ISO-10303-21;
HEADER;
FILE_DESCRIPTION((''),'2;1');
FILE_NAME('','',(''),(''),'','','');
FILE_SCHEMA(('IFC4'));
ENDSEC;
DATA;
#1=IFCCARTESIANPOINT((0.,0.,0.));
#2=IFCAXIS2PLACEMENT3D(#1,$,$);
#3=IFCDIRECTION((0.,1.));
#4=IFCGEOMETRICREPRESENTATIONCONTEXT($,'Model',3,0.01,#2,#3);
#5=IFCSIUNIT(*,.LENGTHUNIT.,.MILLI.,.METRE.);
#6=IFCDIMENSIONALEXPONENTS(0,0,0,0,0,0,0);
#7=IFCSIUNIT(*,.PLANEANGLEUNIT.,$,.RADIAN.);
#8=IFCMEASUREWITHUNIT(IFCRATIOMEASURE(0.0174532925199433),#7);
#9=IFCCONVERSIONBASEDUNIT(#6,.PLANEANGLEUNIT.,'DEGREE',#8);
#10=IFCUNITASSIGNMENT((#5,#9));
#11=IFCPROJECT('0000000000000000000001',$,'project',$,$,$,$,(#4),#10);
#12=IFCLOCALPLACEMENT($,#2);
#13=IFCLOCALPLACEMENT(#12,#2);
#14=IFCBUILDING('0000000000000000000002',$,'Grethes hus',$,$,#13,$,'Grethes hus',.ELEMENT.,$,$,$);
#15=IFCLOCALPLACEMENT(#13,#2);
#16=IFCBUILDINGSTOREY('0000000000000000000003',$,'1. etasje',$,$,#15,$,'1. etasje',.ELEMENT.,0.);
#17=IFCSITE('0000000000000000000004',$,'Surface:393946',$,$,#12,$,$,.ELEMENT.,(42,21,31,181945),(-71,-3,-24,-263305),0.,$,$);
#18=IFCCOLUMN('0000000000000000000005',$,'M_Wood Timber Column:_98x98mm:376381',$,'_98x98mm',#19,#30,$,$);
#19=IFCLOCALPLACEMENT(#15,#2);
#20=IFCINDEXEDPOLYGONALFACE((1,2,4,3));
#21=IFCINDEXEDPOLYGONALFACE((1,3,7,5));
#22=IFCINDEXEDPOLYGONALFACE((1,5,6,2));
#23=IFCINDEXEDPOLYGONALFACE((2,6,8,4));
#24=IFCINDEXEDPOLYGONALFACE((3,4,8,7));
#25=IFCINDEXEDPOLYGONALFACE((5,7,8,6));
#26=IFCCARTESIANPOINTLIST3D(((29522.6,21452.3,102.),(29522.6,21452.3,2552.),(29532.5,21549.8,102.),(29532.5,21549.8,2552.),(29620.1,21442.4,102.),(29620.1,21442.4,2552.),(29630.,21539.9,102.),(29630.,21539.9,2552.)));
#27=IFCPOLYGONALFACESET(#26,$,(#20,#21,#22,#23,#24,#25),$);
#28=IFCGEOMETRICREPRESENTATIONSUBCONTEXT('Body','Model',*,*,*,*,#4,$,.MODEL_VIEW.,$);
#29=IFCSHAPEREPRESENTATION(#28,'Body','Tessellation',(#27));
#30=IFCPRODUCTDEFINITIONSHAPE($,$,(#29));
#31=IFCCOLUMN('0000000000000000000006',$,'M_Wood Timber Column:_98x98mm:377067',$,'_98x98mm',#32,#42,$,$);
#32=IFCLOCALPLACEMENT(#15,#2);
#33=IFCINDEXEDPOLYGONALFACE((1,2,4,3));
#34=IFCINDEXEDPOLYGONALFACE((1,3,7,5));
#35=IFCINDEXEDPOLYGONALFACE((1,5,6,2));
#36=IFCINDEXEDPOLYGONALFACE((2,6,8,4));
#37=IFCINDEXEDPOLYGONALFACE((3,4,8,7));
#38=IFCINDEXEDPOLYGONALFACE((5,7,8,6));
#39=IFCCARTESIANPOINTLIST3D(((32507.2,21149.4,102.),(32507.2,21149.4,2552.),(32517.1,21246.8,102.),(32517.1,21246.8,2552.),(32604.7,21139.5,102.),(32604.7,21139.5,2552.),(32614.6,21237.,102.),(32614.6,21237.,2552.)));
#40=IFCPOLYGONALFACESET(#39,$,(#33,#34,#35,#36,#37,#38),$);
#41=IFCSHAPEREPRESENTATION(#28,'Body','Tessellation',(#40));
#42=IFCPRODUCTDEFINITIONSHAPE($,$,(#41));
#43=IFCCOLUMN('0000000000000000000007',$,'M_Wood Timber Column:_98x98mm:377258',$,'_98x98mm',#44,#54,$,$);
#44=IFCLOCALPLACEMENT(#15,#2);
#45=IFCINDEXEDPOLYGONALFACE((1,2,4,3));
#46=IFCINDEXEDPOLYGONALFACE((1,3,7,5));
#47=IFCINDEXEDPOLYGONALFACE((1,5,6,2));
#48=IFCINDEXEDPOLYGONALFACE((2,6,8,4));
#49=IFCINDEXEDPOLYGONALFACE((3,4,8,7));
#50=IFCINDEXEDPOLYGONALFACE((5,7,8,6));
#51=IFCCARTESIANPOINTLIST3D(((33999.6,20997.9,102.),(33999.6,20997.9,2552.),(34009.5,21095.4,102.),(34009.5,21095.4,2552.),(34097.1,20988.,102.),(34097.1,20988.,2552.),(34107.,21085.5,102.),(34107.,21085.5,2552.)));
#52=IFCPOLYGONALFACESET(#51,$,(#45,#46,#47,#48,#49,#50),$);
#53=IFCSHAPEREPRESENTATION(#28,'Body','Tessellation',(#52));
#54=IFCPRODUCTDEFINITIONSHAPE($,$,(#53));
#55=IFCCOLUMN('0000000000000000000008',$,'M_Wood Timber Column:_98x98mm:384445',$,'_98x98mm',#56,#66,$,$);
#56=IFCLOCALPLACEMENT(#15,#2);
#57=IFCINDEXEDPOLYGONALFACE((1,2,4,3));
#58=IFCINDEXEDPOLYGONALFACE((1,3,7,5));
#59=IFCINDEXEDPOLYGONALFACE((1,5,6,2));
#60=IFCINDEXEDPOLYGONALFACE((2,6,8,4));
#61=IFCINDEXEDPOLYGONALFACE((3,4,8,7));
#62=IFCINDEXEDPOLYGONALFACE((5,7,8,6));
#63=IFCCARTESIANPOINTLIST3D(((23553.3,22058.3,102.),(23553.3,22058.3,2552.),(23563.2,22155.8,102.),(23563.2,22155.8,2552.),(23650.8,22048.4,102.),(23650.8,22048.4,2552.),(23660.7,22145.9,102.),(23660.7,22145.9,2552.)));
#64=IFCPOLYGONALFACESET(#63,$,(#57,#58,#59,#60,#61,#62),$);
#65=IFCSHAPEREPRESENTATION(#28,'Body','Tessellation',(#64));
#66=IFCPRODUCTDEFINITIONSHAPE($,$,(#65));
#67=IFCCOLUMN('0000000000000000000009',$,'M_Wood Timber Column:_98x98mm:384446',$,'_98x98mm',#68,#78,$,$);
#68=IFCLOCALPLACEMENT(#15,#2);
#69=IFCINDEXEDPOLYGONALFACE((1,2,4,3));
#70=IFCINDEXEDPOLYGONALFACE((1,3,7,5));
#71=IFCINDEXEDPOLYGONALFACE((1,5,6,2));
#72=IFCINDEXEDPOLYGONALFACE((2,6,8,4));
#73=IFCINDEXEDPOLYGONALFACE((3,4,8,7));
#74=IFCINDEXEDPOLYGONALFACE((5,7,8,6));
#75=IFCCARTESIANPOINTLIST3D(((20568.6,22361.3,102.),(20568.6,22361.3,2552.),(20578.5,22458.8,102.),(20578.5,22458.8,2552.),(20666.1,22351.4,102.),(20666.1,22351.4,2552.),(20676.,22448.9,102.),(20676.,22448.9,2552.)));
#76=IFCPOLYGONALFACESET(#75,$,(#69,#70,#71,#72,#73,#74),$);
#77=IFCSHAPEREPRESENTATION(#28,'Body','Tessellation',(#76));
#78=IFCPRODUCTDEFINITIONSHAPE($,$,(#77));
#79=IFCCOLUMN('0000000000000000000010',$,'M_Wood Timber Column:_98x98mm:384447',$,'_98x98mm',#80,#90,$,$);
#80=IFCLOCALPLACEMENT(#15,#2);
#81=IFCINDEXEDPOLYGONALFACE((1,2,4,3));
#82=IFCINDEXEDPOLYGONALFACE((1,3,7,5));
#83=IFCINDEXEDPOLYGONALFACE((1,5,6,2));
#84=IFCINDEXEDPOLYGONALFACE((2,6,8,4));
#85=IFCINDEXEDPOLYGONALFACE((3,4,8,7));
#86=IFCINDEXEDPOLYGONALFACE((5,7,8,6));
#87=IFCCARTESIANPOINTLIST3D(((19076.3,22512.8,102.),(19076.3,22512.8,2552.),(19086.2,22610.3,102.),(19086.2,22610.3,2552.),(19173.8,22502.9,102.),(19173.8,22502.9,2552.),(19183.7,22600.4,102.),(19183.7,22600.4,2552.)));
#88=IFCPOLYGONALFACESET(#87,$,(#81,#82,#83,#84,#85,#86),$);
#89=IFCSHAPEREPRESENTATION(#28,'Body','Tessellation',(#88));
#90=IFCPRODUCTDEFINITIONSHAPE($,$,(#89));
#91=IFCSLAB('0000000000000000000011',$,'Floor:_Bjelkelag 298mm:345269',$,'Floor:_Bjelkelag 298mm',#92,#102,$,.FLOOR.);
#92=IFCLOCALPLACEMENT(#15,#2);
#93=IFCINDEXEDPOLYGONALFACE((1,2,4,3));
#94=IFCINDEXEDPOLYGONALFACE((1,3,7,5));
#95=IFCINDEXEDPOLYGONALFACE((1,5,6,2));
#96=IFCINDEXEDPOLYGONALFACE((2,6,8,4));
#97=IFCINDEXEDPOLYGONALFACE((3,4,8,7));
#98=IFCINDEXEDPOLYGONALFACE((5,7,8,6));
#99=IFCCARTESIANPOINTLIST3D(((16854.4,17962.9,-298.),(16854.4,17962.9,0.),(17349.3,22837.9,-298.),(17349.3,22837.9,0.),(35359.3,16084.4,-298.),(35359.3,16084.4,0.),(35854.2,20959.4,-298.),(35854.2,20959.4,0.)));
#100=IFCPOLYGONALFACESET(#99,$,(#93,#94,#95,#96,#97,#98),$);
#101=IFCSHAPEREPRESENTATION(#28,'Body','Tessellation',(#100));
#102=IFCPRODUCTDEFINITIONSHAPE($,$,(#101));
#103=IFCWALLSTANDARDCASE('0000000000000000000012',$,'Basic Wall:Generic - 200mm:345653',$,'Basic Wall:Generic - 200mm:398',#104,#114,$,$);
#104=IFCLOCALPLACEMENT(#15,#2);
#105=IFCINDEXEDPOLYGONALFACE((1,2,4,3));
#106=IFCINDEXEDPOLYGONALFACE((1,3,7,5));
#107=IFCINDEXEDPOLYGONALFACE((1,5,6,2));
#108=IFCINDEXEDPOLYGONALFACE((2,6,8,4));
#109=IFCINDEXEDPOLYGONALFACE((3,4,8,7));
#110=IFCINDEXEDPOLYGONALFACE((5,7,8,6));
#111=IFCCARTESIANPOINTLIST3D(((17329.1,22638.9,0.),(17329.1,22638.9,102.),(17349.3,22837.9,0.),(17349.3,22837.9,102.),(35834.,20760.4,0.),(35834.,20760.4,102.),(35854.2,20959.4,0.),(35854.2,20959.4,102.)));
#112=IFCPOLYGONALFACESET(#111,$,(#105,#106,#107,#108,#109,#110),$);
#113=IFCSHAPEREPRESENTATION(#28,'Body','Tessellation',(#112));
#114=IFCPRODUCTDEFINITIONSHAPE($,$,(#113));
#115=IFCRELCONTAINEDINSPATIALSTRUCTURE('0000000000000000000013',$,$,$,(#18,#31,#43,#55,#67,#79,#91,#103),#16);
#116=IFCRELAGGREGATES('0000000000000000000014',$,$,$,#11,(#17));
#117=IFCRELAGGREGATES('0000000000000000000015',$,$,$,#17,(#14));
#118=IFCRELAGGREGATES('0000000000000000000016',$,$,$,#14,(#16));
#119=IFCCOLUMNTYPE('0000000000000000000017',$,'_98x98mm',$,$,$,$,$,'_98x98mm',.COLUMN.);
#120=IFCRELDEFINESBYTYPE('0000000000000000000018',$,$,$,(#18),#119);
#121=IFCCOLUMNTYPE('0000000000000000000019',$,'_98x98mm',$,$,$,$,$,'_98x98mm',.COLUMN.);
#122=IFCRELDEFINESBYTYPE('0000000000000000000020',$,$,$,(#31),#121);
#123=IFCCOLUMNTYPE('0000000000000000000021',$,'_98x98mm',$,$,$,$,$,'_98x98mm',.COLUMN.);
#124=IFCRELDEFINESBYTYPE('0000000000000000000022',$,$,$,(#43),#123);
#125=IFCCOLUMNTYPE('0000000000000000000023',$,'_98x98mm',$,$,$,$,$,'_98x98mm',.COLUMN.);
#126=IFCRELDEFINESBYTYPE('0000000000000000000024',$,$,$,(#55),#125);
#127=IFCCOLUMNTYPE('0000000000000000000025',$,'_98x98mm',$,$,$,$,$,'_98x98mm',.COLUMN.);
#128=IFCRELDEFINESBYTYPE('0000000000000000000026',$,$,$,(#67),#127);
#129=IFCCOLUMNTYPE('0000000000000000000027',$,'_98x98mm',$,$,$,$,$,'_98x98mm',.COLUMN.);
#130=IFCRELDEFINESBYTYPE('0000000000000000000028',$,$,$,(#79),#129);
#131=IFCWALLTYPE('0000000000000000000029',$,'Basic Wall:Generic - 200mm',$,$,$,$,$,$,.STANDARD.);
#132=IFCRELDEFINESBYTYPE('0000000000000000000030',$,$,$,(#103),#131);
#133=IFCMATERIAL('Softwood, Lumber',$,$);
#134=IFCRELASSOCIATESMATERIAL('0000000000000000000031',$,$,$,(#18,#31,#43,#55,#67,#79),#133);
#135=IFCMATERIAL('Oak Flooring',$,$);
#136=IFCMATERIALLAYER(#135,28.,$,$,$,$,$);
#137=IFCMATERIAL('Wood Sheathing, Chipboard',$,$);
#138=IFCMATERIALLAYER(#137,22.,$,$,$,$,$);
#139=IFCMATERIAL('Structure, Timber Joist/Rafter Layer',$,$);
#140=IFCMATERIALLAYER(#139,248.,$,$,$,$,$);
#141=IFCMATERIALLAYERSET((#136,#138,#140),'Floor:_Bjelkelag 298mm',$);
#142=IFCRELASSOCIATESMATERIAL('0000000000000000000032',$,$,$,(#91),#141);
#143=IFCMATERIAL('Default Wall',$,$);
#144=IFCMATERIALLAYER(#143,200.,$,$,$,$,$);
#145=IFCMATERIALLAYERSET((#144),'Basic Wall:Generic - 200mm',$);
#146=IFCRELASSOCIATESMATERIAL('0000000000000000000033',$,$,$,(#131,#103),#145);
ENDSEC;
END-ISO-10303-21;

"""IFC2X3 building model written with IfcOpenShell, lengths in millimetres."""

from ifc_helpers import new_model, entity, si_unit, converted_unit, direction, frame, frame_2d, origin, place, context, subcontext, project, spatial, rectangle, extrude, source, transform, mapped, material, layer, layer_set, layer_usage, type_object, type_shapes, element, save


model = new_model("IFC2X3")

# Units and contexts
model_context = context("Model", 3, precision=0.01, world=origin(), true_north=direction((0.0, 1.0)))
body_context = subcontext(model_context, "Body", "Model", "MODEL_VIEW")
ifc_project = project(units=[si_unit("LENGTHUNIT", "METRE", prefix="MILLI"), converted_unit("PLANEANGLEUNIT", "DEGREE", entity("IfcRatioMeasure", 0.0174532925199433), si_unit("PLANEANGLEUNIT", "RADIAN"), dimensions=[0, 0, 0, 0, 0, 0, 0])], contexts=[model_context])

# Site, building, storey
site_placement = place(None, origin())
site = spatial("IfcSite", under=ifc_project, at=site_placement, Name="Surface:393946", CompositionType="ELEMENT", RefLatitude=(42, 21, 31, 181945), RefLongitude=(-71, -3, -24, -263305), RefElevation=0.0)
building_placement = place(site_placement, origin())
building = spatial("IfcBuilding", under=site, at=building_placement, Name="Grethes hus", LongName="Grethes hus", CompositionType="ELEMENT")
storey_placement = place(building_placement, origin())
storey = spatial("IfcBuildingStorey", under=building, at=storey_placement, Name="1. etasje", LongName="1. etasje", CompositionType="ELEMENT", Elevation=0.0)

# Columns
ifc_material_1 = material(Name="Softwood, Lumber")
column_type_1 = type_object("IfcColumnType", Name="_98x98mm", ElementType="_98x98mm", PredefinedType="COLUMN")
shared_shape_1 = source(origin(), body_context, "Body", "SweptSolid", [
    extrude(rectangle(XDim=98.0, YDim=98.0, at=frame_2d((0.0, 0.0), x_axis=(1.0, 0.0))), frame((29576.3, 21496.1, 102.0), z_axis=(0.0, 0.0, 1.0), x_axis=(0.100996, 0.994887, 0.0)), (0.0, 0.0, 1.0), 2450.0),
])
type_shapes(column_type_1, [shared_shape_1])
column_1_placement = place(storey_placement, origin())
element("IfcColumn", 1, at=column_1_placement, inside=storey, type_object=column_type_1, material=ifc_material_1, Name="M_Wood Timber Column:_98x98mm:376381", ObjectType="_98x98mm", context=body_context, shape_type="MappedRepresentation", body=[
    mapped(shared_shape_1, transform((0.0, 0.0, 0.0), scale=1.0)),
])
column_type_2 = type_object("IfcColumnType", Name="_98x98mm", ElementType="_98x98mm", PredefinedType="COLUMN")
shared_shape_2 = source(origin(), body_context, "Body", "SweptSolid", [
    extrude(rectangle(XDim=98.0, YDim=98.0, at=frame_2d((0.0, 0.0), x_axis=(1.0, 0.0))), frame((32560.9, 21193.2, 102.0), z_axis=(0.0, 0.0, 1.0), x_axis=(0.100996, 0.994887, 0.0)), (0.0, 0.0, 1.0), 2450.0),
])
type_shapes(column_type_2, [shared_shape_2])
column_2_placement = place(storey_placement, origin())
element("IfcColumn", 2, at=column_2_placement, inside=storey, type_object=column_type_2, material=ifc_material_1, Name="M_Wood Timber Column:_98x98mm:377067", ObjectType="_98x98mm", context=body_context, shape_type="MappedRepresentation", body=[
    mapped(shared_shape_2, transform((0.0, 0.0, 0.0), scale=1.0)),
])
column_type_3 = type_object("IfcColumnType", Name="_98x98mm", ElementType="_98x98mm", PredefinedType="COLUMN")
shared_shape_3 = source(origin(), body_context, "Body", "SweptSolid", [
    extrude(rectangle(XDim=98.0, YDim=98.0, at=frame_2d((0.0, 0.0), x_axis=(1.0, 0.0))), frame((34053.3, 21041.7, 102.0), z_axis=(0.0, 0.0, 1.0), x_axis=(0.100996, 0.994887, 0.0)), (0.0, 0.0, 1.0), 2450.0),
])
type_shapes(column_type_3, [shared_shape_3])
column_3_placement = place(storey_placement, origin())
element("IfcColumn", 3, at=column_3_placement, inside=storey, type_object=column_type_3, material=ifc_material_1, Name="M_Wood Timber Column:_98x98mm:377258", ObjectType="_98x98mm", context=body_context, shape_type="MappedRepresentation", body=[
    mapped(shared_shape_3, transform((0.0, 0.0, 0.0), scale=1.0)),
])
column_type_4 = type_object("IfcColumnType", Name="_98x98mm", ElementType="_98x98mm", PredefinedType="COLUMN")
shared_shape_4 = source(origin(), body_context, "Body", "SweptSolid", [
    extrude(rectangle(XDim=98.0, YDim=98.0, at=frame_2d((0.0, 0.0), x_axis=(1.0, 0.0))), frame((23607.0, 22102.1, 102.0), z_axis=(0.0, 0.0, 1.0), x_axis=(0.100996, 0.994887, 0.0)), (0.0, 0.0, 1.0), 2450.0),
])
type_shapes(column_type_4, [shared_shape_4])
column_4_placement = place(storey_placement, origin())
element("IfcColumn", 4, at=column_4_placement, inside=storey, type_object=column_type_4, material=ifc_material_1, Name="M_Wood Timber Column:_98x98mm:384445", ObjectType="_98x98mm", context=body_context, shape_type="MappedRepresentation", body=[
    mapped(shared_shape_4, transform((0.0, 0.0, 0.0), scale=1.0)),
])
column_type_5 = type_object("IfcColumnType", Name="_98x98mm", ElementType="_98x98mm", PredefinedType="COLUMN")
shared_shape_5 = source(origin(), body_context, "Body", "SweptSolid", [
    extrude(rectangle(XDim=98.0, YDim=98.0, at=frame_2d((0.0, 0.0), x_axis=(1.0, 0.0))), frame((20622.3, 22405.1, 102.0), z_axis=(0.0, 0.0, 1.0), x_axis=(0.100996, 0.994887, 0.0)), (0.0, 0.0, 1.0), 2450.0),
])
type_shapes(column_type_5, [shared_shape_5])
column_5_placement = place(storey_placement, origin())
element("IfcColumn", 5, at=column_5_placement, inside=storey, type_object=column_type_5, material=ifc_material_1, Name="M_Wood Timber Column:_98x98mm:384446", ObjectType="_98x98mm", context=body_context, shape_type="MappedRepresentation", body=[
    mapped(shared_shape_5, transform((0.0, 0.0, 0.0), scale=1.0)),
])
column_type_6 = type_object("IfcColumnType", Name="_98x98mm", ElementType="_98x98mm", PredefinedType="COLUMN")
shared_shape_6 = source(origin(), body_context, "Body", "SweptSolid", [
    extrude(rectangle(XDim=98.0, YDim=98.0, at=frame_2d((0.0, 0.0), x_axis=(1.0, 0.0))), frame((19130.0, 22556.6, 102.0), z_axis=(0.0, 0.0, 1.0), x_axis=(0.100996, 0.994887, 0.0)), (0.0, 0.0, 1.0), 2450.0),
])
type_shapes(column_type_6, [shared_shape_6])
column_6_placement = place(storey_placement, origin())
element("IfcColumn", 6, at=column_6_placement, inside=storey, type_object=column_type_6, material=ifc_material_1, Name="M_Wood Timber Column:_98x98mm:384447", ObjectType="_98x98mm", context=body_context, shape_type="MappedRepresentation", body=[
    mapped(shared_shape_6, transform((0.0, 0.0, 0.0), scale=1.0)),
])

# Slab
ifc_material_2 = material(Name="Oak Flooring")
ifc_layer_1 = layer(ifc_material_2, 28.0)
ifc_material_3 = material(Name="Wood Sheathing, Chipboard")
ifc_layer_2 = layer(ifc_material_3, 22.0)
ifc_material_4 = material(Name="Structure, Timber Joist/Rafter Layer")
ifc_layer_3 = layer(ifc_material_4, 248.0)
ifc_layer_set_1 = layer_set([ifc_layer_1, ifc_layer_2, ifc_layer_3], Name="Floor:_Bjelkelag 298mm")
ifc_layer_usage_1 = layer_usage(ifc_layer_set_1, "AXIS3", "POSITIVE", 0.0)
slab_1_placement = place(storey_placement, origin())
element("IfcSlab", 7, at=slab_1_placement, inside=storey, material=ifc_layer_usage_1, Name="Floor:_Bjelkelag 298mm:345269", ObjectType="Floor:_Bjelkelag 298mm", PredefinedType="FLOOR", context=body_context, shape_type="SweptSolid", body=[
    extrude(rectangle(XDim=18600.0, YDim=4900.0, at=frame_2d((0.0, 0.0), x_axis=(1.0, 0.0))), frame((26354.3, 19461.1, 0.0), z_axis=(0.0, 0.0, -1.0), x_axis=(0.994887, -0.100996, 0.0)), (0.0, 0.0, 1.0), 298.0),
])

# Wall
ifc_material_5 = material(Name="Default Wall")
ifc_layer_4 = layer(ifc_material_5, 200.0)
ifc_layer_set_2 = layer_set([ifc_layer_4], Name="Basic Wall:Generic - 200mm")
ifc_layer_usage_2 = layer_usage(ifc_layer_set_2, "AXIS2", "NEGATIVE", 100.0)
wall_type_1 = type_object("IfcWallType", Name="Basic Wall:Generic - 200mm", PredefinedType="STANDARD", material=ifc_layer_set_2)
wall_1_placement = place(storey_placement, frame((17339.2, 22738.4, 0.0), z_axis=(0.0, 0.0, 1.0), x_axis=(0.994887, -0.100996, 0.0)))
element("IfcWallStandardCase", 8, at=wall_1_placement, inside=storey, type_object=wall_type_1, material=ifc_layer_usage_2, Name="Basic Wall:Generic - 200mm:345653", ObjectType="Basic Wall:Generic - 200mm:398", context=body_context, shape_type="SweptSolid", body=[
    extrude(rectangle(XDim=18600.0, YDim=200.0, at=frame_2d((9300.0, 0.0), x_axis=(-1.0, 0.0))), origin(), (0.0, 0.0, 1.0), 102.0),
])

save(model, "model.ifc")
